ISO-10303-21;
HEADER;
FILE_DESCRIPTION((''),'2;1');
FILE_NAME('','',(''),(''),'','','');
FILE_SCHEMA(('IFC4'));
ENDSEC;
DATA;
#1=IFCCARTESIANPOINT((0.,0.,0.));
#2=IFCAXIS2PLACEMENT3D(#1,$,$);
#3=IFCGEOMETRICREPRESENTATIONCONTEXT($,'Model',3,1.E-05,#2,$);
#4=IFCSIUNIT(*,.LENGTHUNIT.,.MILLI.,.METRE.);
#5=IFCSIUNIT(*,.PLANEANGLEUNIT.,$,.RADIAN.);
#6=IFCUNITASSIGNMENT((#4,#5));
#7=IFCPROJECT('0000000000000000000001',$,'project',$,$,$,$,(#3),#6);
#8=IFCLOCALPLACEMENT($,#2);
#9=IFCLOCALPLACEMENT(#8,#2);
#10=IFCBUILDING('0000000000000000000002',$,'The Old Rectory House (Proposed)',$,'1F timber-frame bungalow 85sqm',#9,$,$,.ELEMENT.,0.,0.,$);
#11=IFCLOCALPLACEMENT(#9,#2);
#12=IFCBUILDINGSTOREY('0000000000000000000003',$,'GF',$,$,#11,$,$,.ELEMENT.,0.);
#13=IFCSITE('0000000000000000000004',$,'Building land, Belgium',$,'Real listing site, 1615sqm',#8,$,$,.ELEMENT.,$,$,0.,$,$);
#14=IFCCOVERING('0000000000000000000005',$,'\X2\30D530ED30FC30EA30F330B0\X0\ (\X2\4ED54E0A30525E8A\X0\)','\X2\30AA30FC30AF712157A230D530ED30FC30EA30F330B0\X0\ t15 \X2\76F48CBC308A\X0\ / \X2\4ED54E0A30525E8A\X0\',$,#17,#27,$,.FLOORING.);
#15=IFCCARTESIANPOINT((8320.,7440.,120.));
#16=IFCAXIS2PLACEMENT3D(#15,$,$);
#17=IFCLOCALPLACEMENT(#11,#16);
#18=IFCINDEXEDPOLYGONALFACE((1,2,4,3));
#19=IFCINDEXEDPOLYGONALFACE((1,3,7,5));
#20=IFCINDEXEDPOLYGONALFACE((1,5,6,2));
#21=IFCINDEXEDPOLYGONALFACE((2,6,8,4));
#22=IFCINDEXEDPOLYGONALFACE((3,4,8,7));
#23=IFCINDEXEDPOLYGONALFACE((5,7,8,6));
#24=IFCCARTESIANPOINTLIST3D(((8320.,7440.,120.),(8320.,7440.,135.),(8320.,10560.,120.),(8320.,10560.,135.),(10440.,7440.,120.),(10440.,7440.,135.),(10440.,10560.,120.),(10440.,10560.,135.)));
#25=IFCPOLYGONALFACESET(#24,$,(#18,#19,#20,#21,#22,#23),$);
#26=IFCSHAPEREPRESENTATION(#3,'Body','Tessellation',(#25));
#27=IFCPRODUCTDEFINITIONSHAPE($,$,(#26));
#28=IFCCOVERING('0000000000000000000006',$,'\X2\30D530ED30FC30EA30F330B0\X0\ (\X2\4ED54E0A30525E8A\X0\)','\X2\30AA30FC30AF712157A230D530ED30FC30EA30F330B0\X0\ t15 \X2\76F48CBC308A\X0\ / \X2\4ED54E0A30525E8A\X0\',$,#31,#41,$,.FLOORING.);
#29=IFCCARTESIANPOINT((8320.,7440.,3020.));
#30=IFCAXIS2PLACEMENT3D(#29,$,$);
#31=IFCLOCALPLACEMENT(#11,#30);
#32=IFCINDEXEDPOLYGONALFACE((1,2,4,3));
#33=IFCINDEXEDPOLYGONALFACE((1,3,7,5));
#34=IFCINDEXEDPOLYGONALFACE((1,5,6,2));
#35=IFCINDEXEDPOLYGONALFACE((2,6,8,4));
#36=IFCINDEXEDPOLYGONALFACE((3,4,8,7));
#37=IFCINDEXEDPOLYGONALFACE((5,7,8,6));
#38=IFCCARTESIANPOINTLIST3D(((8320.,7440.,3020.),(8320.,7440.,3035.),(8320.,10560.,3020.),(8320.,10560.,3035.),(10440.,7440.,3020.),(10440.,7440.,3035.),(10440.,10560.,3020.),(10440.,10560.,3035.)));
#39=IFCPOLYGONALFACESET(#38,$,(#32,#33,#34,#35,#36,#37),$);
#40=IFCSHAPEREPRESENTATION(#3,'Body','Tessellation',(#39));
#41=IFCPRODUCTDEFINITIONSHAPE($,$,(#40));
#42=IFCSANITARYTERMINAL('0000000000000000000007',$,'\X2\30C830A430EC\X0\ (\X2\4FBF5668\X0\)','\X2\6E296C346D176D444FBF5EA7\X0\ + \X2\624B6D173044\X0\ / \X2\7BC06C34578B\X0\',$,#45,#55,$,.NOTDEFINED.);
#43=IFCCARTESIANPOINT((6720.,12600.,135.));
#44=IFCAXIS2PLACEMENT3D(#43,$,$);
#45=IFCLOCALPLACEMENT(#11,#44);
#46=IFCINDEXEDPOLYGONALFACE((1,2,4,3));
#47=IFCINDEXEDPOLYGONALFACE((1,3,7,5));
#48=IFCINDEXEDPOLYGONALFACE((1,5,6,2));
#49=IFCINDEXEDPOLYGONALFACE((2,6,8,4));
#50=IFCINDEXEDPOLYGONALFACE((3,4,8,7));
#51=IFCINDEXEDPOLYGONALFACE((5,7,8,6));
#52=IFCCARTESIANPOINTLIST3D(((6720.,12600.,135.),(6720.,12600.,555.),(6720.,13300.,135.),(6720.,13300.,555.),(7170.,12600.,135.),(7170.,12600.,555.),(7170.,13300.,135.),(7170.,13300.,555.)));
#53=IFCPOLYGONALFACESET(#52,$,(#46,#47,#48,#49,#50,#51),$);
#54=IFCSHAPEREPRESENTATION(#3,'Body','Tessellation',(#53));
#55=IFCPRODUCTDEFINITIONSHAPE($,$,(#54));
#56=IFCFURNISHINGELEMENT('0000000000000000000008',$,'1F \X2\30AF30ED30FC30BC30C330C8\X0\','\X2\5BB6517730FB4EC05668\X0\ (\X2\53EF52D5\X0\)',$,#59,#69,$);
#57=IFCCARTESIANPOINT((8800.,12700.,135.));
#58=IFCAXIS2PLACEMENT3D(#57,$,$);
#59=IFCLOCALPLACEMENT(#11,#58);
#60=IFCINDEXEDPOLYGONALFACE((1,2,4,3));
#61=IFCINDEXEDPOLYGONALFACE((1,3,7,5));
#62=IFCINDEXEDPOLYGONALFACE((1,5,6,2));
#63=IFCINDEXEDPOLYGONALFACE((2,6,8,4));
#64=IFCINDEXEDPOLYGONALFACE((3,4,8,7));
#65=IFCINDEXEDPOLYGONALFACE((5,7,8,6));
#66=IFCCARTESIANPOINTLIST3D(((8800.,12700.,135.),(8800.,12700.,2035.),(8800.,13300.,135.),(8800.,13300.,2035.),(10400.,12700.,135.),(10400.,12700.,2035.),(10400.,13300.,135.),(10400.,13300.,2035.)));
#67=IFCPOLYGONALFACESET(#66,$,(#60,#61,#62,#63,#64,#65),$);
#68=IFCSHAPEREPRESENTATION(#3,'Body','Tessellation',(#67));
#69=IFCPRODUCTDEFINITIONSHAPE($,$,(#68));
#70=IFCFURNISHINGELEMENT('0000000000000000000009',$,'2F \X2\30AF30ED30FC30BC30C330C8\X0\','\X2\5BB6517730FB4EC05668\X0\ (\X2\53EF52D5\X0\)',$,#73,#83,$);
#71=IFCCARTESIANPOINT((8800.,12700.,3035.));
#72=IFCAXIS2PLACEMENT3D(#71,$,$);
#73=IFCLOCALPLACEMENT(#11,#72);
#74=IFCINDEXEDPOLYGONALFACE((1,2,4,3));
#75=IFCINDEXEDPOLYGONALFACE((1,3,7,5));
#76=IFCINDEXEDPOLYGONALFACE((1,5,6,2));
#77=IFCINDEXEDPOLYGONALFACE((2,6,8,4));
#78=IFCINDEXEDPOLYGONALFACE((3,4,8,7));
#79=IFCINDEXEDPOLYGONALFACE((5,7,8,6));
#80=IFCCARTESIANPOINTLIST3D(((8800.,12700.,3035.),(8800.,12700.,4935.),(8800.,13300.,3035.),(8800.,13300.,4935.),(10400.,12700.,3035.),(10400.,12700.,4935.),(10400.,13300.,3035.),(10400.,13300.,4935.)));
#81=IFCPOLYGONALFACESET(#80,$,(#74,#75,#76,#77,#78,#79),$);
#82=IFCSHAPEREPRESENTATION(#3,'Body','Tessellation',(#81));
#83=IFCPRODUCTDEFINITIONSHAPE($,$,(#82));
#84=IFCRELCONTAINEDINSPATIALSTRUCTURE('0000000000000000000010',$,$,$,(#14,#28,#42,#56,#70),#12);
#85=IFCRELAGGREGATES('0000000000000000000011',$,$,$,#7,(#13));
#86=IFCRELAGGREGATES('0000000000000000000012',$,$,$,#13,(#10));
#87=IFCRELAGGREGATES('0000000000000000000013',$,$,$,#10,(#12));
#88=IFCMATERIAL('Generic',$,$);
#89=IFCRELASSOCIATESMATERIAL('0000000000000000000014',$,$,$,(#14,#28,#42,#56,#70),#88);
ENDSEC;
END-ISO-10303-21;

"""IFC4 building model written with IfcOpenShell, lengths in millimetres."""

from ifc_helpers import new_model, si_unit, frame, frame_2d, origin, place, context, project, spatial, rectangle, extrude, material, element, save


model = new_model("IFC4")

# Units and contexts
model_context = context("Model", 3, precision=1e-05, world=origin())
ifc_project = project(units=[si_unit("LENGTHUNIT", "METRE", prefix="MILLI"), si_unit("PLANEANGLEUNIT", "RADIAN")], contexts=[model_context])

# Site, building, storey
site_placement = place(None, origin())
site = spatial("IfcSite", under=ifc_project, at=site_placement, Name="Building land, Belgium", ObjectType="Real listing site, 1615sqm", CompositionType="ELEMENT", RefElevation=0.0)
building_placement = place(site_placement, origin())
building = spatial("IfcBuilding", under=site, at=building_placement, Name="The Old Rectory House (Proposed)", ObjectType="1F timber-frame bungalow 85sqm", CompositionType="ELEMENT", ElevationOfRefHeight=0.0, ElevationOfTerrain=0.0)
storey_placement = place(building_placement, origin())
storey = spatial("IfcBuildingStorey", under=building, at=storey_placement, Name="GF", CompositionType="ELEMENT", Elevation=0.0)

# Shared definitions
ifc_material_1 = material(Name="Generic")

# Coverings
covering_1_placement = place(storey_placement, frame((8320.0, 7440.0, 120.0)))
element("IfcCovering", 1, at=covering_1_placement, inside=storey, material=ifc_material_1, Name="フローリング (仕上げ床)", Description="オーク無垢フローリング t15 直貼り / 仕上げ床", PredefinedType="FLOORING", context=model_context, shape_type="SweptSolid", body=[
    extrude(rectangle(XDim=2120.0, YDim=3120.0, at=frame_2d((1060.0, 1560.0))), frame((8320.0, 7440.0, 120.0)), (0.0, 0.0, 1.0), 15.0),
])
covering_2_placement = place(storey_placement, frame((8320.0, 7440.0, 3020.0)))
element("IfcCovering", 2, at=covering_2_placement, inside=storey, material=ifc_material_1, Name="フローリング (仕上げ床)", Description="オーク無垢フローリング t15 直貼り / 仕上げ床", PredefinedType="FLOORING", context=model_context, shape_type="SweptSolid", body=[
    extrude(rectangle(XDim=2120.0, YDim=3120.0, at=frame_2d((1060.0, 1560.0))), frame((8320.0, 7440.0, 3020.0)), (0.0, 0.0, 1.0), 15.0),
])

# Sanitary terminal
sanitary_terminal_placement = place(storey_placement, frame((6720.0, 12600.0, 135.0)))
element("IfcSanitaryTerminal", 3, at=sanitary_terminal_placement, inside=storey, material=ifc_material_1, Name="トイレ (便器)", Description="温水洗浄便座 + 手洗い / 節水型", PredefinedType="NOTDEFINED", context=model_context, shape_type="SweptSolid", body=[
    extrude(rectangle(XDim=450.0, YDim=700.0, at=frame_2d((225.0, 350.0))), frame((6720.0, 12600.0, 135.0)), (0.0, 0.0, 1.0), 420.0),
])

# Furnishing elements
furnishing_1_placement = place(storey_placement, frame((8800.0, 12700.0, 135.0)))
element("IfcFurnishingElement", 4, at=furnishing_1_placement, inside=storey, material=ifc_material_1, Name="1F クローゼット", Description="家具・什器 (可動)", context=model_context, shape_type="SweptSolid", body=[
    extrude(rectangle(XDim=1600.0, YDim=600.0, at=frame_2d((800.0, 300.0))), frame((8800.0, 12700.0, 135.0)), (0.0, 0.0, 1.0), 1900.0),
])
furnishing_2_placement = place(storey_placement, frame((8800.0, 12700.0, 3035.0)))
element("IfcFurnishingElement", 5, at=furnishing_2_placement, inside=storey, material=ifc_material_1, Name="2F クローゼット", Description="家具・什器 (可動)", context=model_context, shape_type="SweptSolid", body=[
    extrude(rectangle(XDim=1600.0, YDim=600.0, at=frame_2d((800.0, 300.0))), frame((8800.0, 12700.0, 3035.0)), (0.0, 0.0, 1.0), 1900.0),
])

save(model, "model.ifc")
